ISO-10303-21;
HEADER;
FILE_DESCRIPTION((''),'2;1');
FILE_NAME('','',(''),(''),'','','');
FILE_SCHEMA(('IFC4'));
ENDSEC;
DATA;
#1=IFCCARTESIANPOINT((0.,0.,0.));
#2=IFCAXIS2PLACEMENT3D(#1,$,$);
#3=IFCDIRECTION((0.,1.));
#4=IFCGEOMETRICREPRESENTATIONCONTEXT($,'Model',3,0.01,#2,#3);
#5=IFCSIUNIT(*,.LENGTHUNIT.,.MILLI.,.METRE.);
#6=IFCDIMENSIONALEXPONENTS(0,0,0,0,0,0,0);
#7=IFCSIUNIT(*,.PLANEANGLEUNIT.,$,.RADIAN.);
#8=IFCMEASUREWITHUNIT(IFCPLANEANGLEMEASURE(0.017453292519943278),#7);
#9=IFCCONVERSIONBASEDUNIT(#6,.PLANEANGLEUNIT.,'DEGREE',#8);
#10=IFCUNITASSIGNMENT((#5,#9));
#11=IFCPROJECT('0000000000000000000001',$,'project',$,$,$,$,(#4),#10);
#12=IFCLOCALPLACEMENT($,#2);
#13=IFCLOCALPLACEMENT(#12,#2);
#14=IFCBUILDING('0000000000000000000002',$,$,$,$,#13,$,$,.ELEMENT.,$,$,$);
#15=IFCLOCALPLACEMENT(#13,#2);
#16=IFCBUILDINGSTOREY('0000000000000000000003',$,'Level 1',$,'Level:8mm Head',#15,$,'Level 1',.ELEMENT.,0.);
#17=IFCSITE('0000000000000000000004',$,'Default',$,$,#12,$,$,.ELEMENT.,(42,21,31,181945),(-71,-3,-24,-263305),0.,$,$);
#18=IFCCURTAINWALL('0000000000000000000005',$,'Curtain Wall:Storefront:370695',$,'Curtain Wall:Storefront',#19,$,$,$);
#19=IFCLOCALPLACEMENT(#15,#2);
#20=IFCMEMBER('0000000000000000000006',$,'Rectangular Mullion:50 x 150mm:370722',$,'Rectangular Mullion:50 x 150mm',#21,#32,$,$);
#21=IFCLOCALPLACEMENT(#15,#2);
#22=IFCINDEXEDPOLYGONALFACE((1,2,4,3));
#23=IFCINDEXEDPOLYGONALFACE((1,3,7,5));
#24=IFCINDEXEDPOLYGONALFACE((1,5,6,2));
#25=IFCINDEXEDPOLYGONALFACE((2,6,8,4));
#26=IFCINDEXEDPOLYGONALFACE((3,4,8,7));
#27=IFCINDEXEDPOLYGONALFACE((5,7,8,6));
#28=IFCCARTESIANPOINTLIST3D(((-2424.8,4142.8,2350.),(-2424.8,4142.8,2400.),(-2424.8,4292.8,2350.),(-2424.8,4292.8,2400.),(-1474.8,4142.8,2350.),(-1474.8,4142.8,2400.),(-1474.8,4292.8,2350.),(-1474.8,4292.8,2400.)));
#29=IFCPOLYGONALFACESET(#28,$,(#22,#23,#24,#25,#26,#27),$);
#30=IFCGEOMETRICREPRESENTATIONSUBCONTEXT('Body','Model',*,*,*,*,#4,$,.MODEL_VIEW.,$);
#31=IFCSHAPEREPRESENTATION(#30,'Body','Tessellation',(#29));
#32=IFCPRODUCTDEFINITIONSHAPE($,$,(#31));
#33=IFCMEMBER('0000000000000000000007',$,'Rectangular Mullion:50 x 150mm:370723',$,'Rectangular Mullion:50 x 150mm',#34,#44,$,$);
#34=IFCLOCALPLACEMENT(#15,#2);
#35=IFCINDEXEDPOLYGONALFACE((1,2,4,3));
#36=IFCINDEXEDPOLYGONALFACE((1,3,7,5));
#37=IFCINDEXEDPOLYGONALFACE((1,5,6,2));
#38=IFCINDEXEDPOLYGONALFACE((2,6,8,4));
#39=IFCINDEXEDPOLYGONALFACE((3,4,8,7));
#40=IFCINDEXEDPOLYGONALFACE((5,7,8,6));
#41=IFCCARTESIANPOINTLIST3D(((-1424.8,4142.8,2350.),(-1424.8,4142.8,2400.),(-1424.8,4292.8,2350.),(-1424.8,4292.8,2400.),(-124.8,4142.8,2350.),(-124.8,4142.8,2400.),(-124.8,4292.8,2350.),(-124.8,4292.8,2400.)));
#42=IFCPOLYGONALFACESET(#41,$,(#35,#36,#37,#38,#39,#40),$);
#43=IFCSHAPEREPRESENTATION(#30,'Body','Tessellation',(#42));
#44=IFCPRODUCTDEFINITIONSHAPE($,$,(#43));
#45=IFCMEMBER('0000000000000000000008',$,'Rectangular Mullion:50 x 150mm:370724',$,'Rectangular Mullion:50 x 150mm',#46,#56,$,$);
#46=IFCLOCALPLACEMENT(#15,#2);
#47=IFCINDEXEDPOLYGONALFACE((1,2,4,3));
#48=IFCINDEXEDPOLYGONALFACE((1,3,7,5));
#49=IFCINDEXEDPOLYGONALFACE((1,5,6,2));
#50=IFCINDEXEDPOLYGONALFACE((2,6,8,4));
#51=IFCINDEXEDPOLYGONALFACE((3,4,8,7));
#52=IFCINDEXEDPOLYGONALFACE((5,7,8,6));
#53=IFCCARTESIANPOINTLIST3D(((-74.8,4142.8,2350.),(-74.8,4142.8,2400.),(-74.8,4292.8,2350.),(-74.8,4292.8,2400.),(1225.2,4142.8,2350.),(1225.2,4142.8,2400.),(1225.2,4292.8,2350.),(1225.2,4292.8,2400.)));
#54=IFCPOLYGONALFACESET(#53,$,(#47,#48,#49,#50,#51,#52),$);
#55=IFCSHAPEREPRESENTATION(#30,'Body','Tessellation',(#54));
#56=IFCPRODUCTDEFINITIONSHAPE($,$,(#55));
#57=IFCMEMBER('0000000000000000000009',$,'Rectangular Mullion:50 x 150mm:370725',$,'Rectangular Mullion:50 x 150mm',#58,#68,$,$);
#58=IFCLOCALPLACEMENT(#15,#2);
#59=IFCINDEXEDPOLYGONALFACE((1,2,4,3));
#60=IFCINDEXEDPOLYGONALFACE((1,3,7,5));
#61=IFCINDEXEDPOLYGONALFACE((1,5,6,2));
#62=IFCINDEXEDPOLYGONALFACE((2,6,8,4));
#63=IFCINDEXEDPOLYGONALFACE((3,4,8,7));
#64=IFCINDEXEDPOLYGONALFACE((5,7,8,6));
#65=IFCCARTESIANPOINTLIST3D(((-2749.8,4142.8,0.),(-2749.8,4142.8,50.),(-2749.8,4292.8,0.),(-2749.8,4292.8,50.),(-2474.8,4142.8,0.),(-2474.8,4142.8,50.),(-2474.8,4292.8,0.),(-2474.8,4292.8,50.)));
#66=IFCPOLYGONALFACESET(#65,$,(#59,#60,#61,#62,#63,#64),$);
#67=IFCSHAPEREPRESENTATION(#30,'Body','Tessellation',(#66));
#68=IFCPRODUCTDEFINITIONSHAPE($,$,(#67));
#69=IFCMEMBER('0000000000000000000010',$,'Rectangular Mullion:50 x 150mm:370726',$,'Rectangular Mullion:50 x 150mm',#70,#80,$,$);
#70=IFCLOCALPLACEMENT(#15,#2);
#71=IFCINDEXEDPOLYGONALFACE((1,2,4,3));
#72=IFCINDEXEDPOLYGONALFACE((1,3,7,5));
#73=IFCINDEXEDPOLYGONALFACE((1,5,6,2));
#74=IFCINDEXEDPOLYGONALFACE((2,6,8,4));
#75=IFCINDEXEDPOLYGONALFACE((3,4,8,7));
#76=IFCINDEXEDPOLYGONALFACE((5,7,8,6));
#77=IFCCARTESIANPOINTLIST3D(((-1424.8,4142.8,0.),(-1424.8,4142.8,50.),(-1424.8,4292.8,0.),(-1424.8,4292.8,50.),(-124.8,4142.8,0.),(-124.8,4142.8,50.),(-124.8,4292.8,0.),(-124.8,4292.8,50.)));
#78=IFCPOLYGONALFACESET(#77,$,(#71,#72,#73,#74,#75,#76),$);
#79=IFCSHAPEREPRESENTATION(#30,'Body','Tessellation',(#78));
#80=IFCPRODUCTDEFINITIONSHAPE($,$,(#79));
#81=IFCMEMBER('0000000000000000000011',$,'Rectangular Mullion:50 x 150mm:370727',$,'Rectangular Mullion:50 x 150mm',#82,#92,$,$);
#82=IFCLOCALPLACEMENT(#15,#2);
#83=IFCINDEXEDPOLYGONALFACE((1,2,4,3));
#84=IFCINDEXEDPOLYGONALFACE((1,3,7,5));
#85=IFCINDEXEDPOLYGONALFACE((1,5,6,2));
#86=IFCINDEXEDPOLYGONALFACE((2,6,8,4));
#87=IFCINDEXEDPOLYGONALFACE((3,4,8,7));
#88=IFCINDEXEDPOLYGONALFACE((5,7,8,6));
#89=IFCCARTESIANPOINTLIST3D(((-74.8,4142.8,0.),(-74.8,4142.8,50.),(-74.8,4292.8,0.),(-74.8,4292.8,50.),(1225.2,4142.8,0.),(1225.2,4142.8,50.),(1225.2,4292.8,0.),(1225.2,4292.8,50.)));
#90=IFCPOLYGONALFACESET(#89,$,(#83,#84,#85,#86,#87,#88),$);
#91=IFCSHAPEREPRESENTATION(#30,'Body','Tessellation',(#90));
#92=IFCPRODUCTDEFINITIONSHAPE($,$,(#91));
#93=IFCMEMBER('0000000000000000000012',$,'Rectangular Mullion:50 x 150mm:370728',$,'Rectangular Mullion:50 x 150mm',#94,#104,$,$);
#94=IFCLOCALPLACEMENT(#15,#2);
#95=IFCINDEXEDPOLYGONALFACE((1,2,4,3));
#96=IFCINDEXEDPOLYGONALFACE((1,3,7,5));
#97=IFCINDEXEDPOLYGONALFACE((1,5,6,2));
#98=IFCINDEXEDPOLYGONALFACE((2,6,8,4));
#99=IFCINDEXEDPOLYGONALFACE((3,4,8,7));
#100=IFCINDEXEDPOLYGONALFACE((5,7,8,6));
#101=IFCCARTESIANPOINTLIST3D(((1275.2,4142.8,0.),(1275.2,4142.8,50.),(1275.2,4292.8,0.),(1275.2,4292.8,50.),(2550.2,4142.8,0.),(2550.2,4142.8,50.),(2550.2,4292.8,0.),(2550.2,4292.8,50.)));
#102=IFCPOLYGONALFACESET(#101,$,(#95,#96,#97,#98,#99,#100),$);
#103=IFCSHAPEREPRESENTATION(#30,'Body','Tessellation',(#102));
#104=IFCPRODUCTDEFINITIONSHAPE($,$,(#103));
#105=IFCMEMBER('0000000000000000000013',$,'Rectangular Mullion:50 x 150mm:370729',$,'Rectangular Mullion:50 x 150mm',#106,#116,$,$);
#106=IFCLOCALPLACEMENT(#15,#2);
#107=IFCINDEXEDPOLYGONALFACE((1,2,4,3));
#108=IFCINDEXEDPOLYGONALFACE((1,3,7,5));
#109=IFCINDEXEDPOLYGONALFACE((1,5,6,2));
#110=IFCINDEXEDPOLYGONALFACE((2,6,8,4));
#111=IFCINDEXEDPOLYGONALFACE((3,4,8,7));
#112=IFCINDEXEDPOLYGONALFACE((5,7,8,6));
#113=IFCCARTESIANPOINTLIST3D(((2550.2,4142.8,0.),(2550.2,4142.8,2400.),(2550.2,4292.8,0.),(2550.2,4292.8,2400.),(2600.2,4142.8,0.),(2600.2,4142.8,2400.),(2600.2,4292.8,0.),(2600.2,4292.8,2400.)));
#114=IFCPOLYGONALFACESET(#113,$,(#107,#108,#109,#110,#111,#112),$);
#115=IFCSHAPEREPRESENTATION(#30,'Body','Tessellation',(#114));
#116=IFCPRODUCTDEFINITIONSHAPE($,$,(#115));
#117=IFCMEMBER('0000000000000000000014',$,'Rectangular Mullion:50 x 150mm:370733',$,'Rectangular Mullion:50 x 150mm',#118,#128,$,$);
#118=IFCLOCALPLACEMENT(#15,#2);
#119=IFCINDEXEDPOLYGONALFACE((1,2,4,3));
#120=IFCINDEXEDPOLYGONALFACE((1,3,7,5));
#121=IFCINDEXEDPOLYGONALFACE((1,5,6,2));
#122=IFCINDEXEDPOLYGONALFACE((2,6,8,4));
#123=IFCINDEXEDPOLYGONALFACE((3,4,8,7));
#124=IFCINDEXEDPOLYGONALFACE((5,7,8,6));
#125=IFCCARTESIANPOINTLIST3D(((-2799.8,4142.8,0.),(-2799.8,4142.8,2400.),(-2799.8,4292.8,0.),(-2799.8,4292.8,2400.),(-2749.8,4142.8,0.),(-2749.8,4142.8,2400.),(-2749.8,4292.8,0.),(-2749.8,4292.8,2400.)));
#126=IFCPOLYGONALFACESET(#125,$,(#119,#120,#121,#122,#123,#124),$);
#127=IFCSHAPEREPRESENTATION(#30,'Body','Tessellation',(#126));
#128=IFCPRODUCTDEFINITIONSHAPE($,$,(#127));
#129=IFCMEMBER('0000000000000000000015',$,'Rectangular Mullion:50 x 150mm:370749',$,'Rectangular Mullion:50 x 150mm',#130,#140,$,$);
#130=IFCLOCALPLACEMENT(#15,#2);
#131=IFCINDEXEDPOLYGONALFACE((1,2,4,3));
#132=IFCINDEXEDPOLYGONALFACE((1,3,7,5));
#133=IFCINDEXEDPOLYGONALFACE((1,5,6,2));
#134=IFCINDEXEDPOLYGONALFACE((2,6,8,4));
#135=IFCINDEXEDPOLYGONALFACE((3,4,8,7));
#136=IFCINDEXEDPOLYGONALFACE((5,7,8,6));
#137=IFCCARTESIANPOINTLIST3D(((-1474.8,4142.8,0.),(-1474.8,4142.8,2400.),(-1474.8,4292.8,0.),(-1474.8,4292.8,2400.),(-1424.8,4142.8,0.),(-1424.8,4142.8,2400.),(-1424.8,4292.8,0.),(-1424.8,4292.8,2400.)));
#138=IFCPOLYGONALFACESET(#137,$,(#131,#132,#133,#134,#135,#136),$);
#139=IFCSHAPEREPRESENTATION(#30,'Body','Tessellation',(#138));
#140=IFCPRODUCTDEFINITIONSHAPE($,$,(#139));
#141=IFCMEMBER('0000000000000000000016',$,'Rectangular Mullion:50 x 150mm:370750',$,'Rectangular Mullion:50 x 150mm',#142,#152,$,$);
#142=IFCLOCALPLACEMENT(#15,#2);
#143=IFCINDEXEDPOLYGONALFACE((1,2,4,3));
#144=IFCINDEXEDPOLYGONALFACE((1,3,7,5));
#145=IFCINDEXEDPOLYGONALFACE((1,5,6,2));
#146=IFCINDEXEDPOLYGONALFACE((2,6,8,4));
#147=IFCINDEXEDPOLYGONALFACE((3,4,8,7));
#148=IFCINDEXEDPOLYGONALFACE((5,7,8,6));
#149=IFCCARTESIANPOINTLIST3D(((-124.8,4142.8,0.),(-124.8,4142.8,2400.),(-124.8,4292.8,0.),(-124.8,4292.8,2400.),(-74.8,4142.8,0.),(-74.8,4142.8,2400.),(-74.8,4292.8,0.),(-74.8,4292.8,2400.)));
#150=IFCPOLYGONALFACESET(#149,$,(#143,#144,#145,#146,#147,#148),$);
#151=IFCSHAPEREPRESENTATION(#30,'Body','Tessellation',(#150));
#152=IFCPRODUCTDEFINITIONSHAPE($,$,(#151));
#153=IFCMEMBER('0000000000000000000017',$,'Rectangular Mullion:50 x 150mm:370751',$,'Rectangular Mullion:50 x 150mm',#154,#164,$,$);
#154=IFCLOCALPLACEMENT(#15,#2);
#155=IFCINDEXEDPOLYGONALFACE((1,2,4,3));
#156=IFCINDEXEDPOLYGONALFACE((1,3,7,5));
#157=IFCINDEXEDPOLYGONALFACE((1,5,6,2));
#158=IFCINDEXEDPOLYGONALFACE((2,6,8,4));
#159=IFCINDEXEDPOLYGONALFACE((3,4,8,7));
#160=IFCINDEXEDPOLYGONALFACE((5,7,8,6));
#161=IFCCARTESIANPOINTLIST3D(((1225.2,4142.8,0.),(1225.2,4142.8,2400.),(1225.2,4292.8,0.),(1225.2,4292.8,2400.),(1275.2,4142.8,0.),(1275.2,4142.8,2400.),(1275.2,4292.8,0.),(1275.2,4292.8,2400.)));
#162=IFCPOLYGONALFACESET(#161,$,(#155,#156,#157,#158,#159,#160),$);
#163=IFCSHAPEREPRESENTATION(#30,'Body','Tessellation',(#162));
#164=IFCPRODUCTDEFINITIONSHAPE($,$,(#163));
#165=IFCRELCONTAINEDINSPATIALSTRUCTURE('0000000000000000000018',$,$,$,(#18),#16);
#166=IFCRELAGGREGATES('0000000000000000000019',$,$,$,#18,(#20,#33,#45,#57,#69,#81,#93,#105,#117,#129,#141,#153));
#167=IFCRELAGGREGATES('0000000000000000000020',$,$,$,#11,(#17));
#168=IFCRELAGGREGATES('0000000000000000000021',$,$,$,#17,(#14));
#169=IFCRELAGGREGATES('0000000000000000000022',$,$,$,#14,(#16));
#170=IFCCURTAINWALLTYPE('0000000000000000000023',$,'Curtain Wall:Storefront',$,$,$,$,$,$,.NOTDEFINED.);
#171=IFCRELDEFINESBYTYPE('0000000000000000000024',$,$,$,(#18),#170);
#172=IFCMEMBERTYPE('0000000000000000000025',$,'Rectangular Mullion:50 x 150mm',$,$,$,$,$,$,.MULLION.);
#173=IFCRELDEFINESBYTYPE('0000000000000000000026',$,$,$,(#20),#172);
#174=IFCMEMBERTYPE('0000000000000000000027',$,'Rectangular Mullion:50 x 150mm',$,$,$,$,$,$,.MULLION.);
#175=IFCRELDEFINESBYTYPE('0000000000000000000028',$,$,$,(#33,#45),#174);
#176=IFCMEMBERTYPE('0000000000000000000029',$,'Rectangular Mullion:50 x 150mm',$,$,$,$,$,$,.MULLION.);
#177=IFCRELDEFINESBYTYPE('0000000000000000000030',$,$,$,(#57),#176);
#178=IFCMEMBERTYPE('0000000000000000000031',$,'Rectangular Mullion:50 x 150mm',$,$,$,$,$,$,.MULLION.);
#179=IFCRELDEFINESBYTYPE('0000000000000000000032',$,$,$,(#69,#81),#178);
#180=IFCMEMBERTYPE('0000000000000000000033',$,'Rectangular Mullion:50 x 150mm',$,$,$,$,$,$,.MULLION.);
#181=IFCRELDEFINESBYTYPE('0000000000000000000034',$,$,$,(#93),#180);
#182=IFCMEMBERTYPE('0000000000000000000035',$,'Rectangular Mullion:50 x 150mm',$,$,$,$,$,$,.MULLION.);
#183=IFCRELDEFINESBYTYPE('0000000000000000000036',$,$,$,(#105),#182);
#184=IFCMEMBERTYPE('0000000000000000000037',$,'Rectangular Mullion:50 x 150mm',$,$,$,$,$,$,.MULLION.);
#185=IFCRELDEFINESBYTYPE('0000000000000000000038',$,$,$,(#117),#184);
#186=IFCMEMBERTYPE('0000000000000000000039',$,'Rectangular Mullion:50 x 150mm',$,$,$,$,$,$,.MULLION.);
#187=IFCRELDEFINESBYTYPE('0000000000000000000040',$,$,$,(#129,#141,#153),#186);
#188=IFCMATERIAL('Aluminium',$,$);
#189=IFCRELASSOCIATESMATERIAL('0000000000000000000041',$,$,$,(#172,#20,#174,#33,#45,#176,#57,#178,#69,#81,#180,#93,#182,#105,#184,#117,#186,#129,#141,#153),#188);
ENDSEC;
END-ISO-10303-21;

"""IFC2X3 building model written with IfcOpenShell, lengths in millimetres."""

from ifc_helpers import new_model, entity, si_unit, converted_unit, direction, frame, origin, origin_2d_with_axis, place, context, subcontext, project, spatial, rectangle, extrude, source, transform, mapped, material, type_object, type_shapes, element, aggregate, save


model = new_model("IFC2X3")

# Units and contexts
model_context = context("Model", 3, precision=0.01, world=origin(), true_north=direction((0.0, 1.0)))
body_context = subcontext(model_context, "Body", "Model", "MODEL_VIEW")
ifc_project = project(units=[si_unit("LENGTHUNIT", "METRE", prefix="MILLI"), converted_unit("PLANEANGLEUNIT", "DEGREE", entity("IfcPlaneAngleMeasure", 0.017453292519943278), si_unit("PLANEANGLEUNIT", "RADIAN"), dimensions=[0, 0, 0, 0, 0, 0, 0])], contexts=[model_context])

# Site, building, storey
site_placement = place(None, origin())
site = spatial("IfcSite", under=ifc_project, at=site_placement, Name="Default", CompositionType="ELEMENT", RefLatitude=(42, 21, 31, 181945), RefLongitude=(-71, -3, -24, -263305), RefElevation=0.0)
building_placement = place(site_placement, origin())
building = spatial("IfcBuilding", under=site, at=building_placement, CompositionType="ELEMENT")
storey_placement = place(building_placement, origin())
storey = spatial("IfcBuildingStorey", under=building, at=storey_placement, Name="Level 1", ObjectType="Level:8mm Head", LongName="Level 1", CompositionType="ELEMENT", Elevation=0.0)

# Curtain wall, members
curtain_wall_type = type_object("IfcCurtainWallType", Name="Curtain Wall:Storefront", PredefinedType="NOTDEFINED")
curtain_wall_placement = place(storey_placement, origin())
curtain_wall = element("IfcCurtainWall", 1, at=curtain_wall_placement, inside=storey, type_object=curtain_wall_type, Name="Curtain Wall:Storefront:370695", ObjectType="Curtain Wall:Storefront")
ifc_material_1 = material(Name="Aluminium")
member_type_1 = type_object("IfcMemberType", Name="Rectangular Mullion:50 x 150mm", PredefinedType="MULLION", material=ifc_material_1)
shared_shape_1 = source(origin(), body_context, "Body", "SweptSolid", [
    extrude(rectangle(XDim=50.0, YDim=150.0, at=origin_2d_with_axis()), frame((-25.0, 0.0, -950.0), z_axis=(0.0, 0.0, 1.0), x_axis=(-1.0, 0.0, 0.0)), (0.0, 0.0, 1.0), 950.0),
])
type_shapes(member_type_1, [shared_shape_1])
member_1_placement = place(curtain_wall_placement, frame((-1474.8, 4217.8, 2400.0), z_axis=(1.0, 0.0, 0.0), x_axis=(0.0, 0.0, 1.0)))
member_1 = element("IfcMember", 2, at=member_1_placement, type_object=member_type_1, material=ifc_material_1, Name="Rectangular Mullion:50 x 150mm:370722", ObjectType="Rectangular Mullion:50 x 150mm", context=body_context, shape_type="MappedRepresentation", body=[
    mapped(shared_shape_1, transform((0.0, 0.0, 0.0), scale=1.0)),
])
member_type_2 = type_object("IfcMemberType", Name="Rectangular Mullion:50 x 150mm", PredefinedType="MULLION", material=ifc_material_1)
shared_shape_2 = source(origin(), body_context, "Body", "SweptSolid", [
    extrude(rectangle(XDim=50.0, YDim=150.0, at=origin_2d_with_axis()), frame((-25.0, 0.0, -1300.0), z_axis=(0.0, 0.0, 1.0), x_axis=(-1.0, 0.0, 0.0)), (0.0, 0.0, 1.0), 1300.0),
])
type_shapes(member_type_2, [shared_shape_2])
member_2_placement = place(curtain_wall_placement, frame((-124.8, 4217.8, 2400.0), z_axis=(1.0, 0.0, 0.0), x_axis=(0.0, 0.0, 1.0)))
member_2 = element("IfcMember", 3, at=member_2_placement, type_object=member_type_2, material=ifc_material_1, Name="Rectangular Mullion:50 x 150mm:370723", ObjectType="Rectangular Mullion:50 x 150mm", context=body_context, shape_type="MappedRepresentation", body=[
    mapped(shared_shape_2, transform((0.0, 0.0, 0.0), scale=1.0)),
])
member_3_placement = place(curtain_wall_placement, frame((1225.2, 4217.8, 2400.0), z_axis=(1.0, 0.0, 0.0), x_axis=(0.0, 0.0, 1.0)))
member_3 = element("IfcMember", 4, at=member_3_placement, type_object=member_type_2, material=ifc_material_1, Name="Rectangular Mullion:50 x 150mm:370724", ObjectType="Rectangular Mullion:50 x 150mm", context=body_context, shape_type="MappedRepresentation", body=[
    mapped(shared_shape_2, transform((0.0, 0.0, 0.0), scale=1.0)),
])
member_type_3 = type_object("IfcMemberType", Name="Rectangular Mullion:50 x 150mm", PredefinedType="MULLION", material=ifc_material_1)
shared_shape_3 = source(origin(), body_context, "Body", "SweptSolid", [
    extrude(rectangle(XDim=50.0, YDim=150.0, at=origin_2d_with_axis()), frame((-25.0, 0.0, -275.0), z_axis=(0.0, 0.0, 1.0), x_axis=(-1.0, 0.0, 0.0)), (0.0, 0.0, 1.0), 275.0),
])
type_shapes(member_type_3, [shared_shape_3])
member_4_placement = place(curtain_wall_placement, frame((-2749.8, 4217.8, 0.0), z_axis=(-1.0, 0.0, 0.0), x_axis=(0.0, 0.0, -1.0)))
member_4 = element("IfcMember", 5, at=member_4_placement, type_object=member_type_3, material=ifc_material_1, Name="Rectangular Mullion:50 x 150mm:370725", ObjectType="Rectangular Mullion:50 x 150mm", context=body_context, shape_type="MappedRepresentation", body=[
    mapped(shared_shape_3, transform((0.0, 0.0, 0.0), scale=1.0)),
])
member_type_4 = type_object("IfcMemberType", Name="Rectangular Mullion:50 x 150mm", PredefinedType="MULLION", material=ifc_material_1)
shared_shape_4 = source(origin(), body_context, "Body", "SweptSolid", [
    extrude(rectangle(XDim=50.0, YDim=150.0, at=origin_2d_with_axis()), frame((-25.0, 0.0, -1300.0), z_axis=(0.0, 0.0, 1.0), x_axis=(-1.0, 0.0, 0.0)), (0.0, 0.0, 1.0), 1300.0),
])
type_shapes(member_type_4, [shared_shape_4])
member_5_placement = place(curtain_wall_placement, frame((-1424.8, 4217.8, 0.0), z_axis=(-1.0, 0.0, 0.0), x_axis=(0.0, 0.0, -1.0)))
member_5 = element("IfcMember", 6, at=member_5_placement, type_object=member_type_4, material=ifc_material_1, Name="Rectangular Mullion:50 x 150mm:370726", ObjectType="Rectangular Mullion:50 x 150mm", context=body_context, shape_type="MappedRepresentation", body=[
    mapped(shared_shape_4, transform((0.0, 0.0, 0.0), scale=1.0)),
])
member_6_placement = place(curtain_wall_placement, frame((-74.8, 4217.8, 0.0), z_axis=(-1.0, 0.0, 0.0), x_axis=(0.0, 0.0, -1.0)))
member_6 = element("IfcMember", 7, at=member_6_placement, type_object=member_type_4, material=ifc_material_1, Name="Rectangular Mullion:50 x 150mm:370727", ObjectType="Rectangular Mullion:50 x 150mm", context=body_context, shape_type="MappedRepresentation", body=[
    mapped(shared_shape_4, transform((0.0, 0.0, 0.0), scale=1.0)),
])
member_type_5 = type_object("IfcMemberType", Name="Rectangular Mullion:50 x 150mm", PredefinedType="MULLION", material=ifc_material_1)
shared_shape_5 = source(origin(), body_context, "Body", "SweptSolid", [
    extrude(rectangle(XDim=50.0, YDim=150.0, at=origin_2d_with_axis()), frame((-25.0, 0.0, -1275.0), z_axis=(0.0, 0.0, 1.0), x_axis=(-1.0, 0.0, 0.0)), (0.0, 0.0, 1.0), 1275.0),
])
type_shapes(member_type_5, [shared_shape_5])
member_7_placement = place(curtain_wall_placement, frame((1275.2, 4217.8, 0.0), z_axis=(-1.0, 0.0, 0.0), x_axis=(0.0, 0.0, -1.0)))
member_7 = element("IfcMember", 8, at=member_7_placement, type_object=member_type_5, material=ifc_material_1, Name="Rectangular Mullion:50 x 150mm:370728", ObjectType="Rectangular Mullion:50 x 150mm", context=body_context, shape_type="MappedRepresentation", body=[
    mapped(shared_shape_5, transform((0.0, 0.0, 0.0), scale=1.0)),
])
member_type_6 = type_object("IfcMemberType", Name="Rectangular Mullion:50 x 150mm", PredefinedType="MULLION", material=ifc_material_1)
shared_shape_6 = source(origin(), body_context, "Body", "SweptSolid", [
    extrude(rectangle(XDim=50.0, YDim=150.0, at=origin_2d_with_axis()), frame((-25.0, 0.0, -2400.0), z_axis=(0.0, 0.0, 1.0), x_axis=(-1.0, 0.0, 0.0)), (0.0, 0.0, 1.0), 2400.0),
])
type_shapes(member_type_6, [shared_shape_6])
member_8_placement = place(curtain_wall_placement, frame((2600.2, 4217.8, 0.0), z_axis=(0.0, 0.0, -1.0), x_axis=(1.0, 0.0, 0.0)))
member_8 = element("IfcMember", 9, at=member_8_placement, type_object=member_type_6, material=ifc_material_1, Name="Rectangular Mullion:50 x 150mm:370729", ObjectType="Rectangular Mullion:50 x 150mm", context=body_context, shape_type="MappedRepresentation", body=[
    mapped(shared_shape_6, transform((0.0, 0.0, 0.0), scale=1.0)),
])
member_type_7 = type_object("IfcMemberType", Name="Rectangular Mullion:50 x 150mm", PredefinedType="MULLION", material=ifc_material_1)
shared_shape_7 = source(origin(), body_context, "Body", "SweptSolid", [
    extrude(rectangle(XDim=50.0, YDim=150.0, at=origin_2d_with_axis()), frame((-25.0, 0.0, -2400.0), z_axis=(0.0, 0.0, 1.0), x_axis=(-1.0, 0.0, 0.0)), (0.0, 0.0, 1.0), 2400.0),
])
type_shapes(member_type_7, [shared_shape_7])
member_9_placement = place(curtain_wall_placement, frame((-2799.8, 4217.8, 2400.0), z_axis=(0.0, 0.0, 1.0), x_axis=(-1.0, 0.0, 0.0)))
member_9 = element("IfcMember", 10, at=member_9_placement, type_object=member_type_7, material=ifc_material_1, Name="Rectangular Mullion:50 x 150mm:370733", ObjectType="Rectangular Mullion:50 x 150mm", context=body_context, shape_type="MappedRepresentation", body=[
    mapped(shared_shape_7, transform((0.0, 0.0, 0.0), scale=1.0)),
])
member_type_8 = type_object("IfcMemberType", Name="Rectangular Mullion:50 x 150mm", PredefinedType="MULLION", material=ifc_material_1)
shared_shape_8 = source(origin(), body_context, "Body", "SweptSolid", [
    extrude(rectangle(XDim=50.0, YDim=150.0, at=origin_2d_with_axis()), frame((0.0, 0.0, -2400.0), z_axis=(0.0, 0.0, 1.0), x_axis=(-1.0, 0.0, 0.0)), (0.0, 0.0, 1.0), 2400.0),
])
type_shapes(member_type_8, [shared_shape_8])
member_10_placement = place(curtain_wall_placement, frame((-1449.8, 4217.8, 0.0), z_axis=(0.0, 0.0, -1.0), x_axis=(1.0, 0.0, 0.0)))
member_10 = element("IfcMember", 11, at=member_10_placement, type_object=member_type_8, material=ifc_material_1, Name="Rectangular Mullion:50 x 150mm:370749", ObjectType="Rectangular Mullion:50 x 150mm", context=body_context, shape_type="MappedRepresentation", body=[
    mapped(shared_shape_8, transform((0.0, 0.0, 0.0), scale=1.0)),
])
member_11_placement = place(curtain_wall_placement, frame((-99.8, 4217.8, 0.0), z_axis=(0.0, 0.0, -1.0), x_axis=(1.0, 0.0, 0.0)))
member_11 = element("IfcMember", 12, at=member_11_placement, type_object=member_type_8, material=ifc_material_1, Name="Rectangular Mullion:50 x 150mm:370750", ObjectType="Rectangular Mullion:50 x 150mm", context=body_context, shape_type="MappedRepresentation", body=[
    mapped(shared_shape_8, transform((0.0, 0.0, 0.0), scale=1.0)),
])
member_12_placement = place(curtain_wall_placement, frame((1250.2, 4217.8, 0.0), z_axis=(0.0, 0.0, -1.0), x_axis=(1.0, 0.0, 0.0)))
member_12 = element("IfcMember", 13, at=member_12_placement, type_object=member_type_8, material=ifc_material_1, Name="Rectangular Mullion:50 x 150mm:370751", ObjectType="Rectangular Mullion:50 x 150mm", context=body_context, shape_type="MappedRepresentation", body=[
    mapped(shared_shape_8, transform((0.0, 0.0, 0.0), scale=1.0)),
])

aggregate(curtain_wall, [member_1, member_2, member_3, member_4, member_5, member_6, member_7, member_8, member_9, member_10, member_11, member_12])

save(model, "model.ifc")
